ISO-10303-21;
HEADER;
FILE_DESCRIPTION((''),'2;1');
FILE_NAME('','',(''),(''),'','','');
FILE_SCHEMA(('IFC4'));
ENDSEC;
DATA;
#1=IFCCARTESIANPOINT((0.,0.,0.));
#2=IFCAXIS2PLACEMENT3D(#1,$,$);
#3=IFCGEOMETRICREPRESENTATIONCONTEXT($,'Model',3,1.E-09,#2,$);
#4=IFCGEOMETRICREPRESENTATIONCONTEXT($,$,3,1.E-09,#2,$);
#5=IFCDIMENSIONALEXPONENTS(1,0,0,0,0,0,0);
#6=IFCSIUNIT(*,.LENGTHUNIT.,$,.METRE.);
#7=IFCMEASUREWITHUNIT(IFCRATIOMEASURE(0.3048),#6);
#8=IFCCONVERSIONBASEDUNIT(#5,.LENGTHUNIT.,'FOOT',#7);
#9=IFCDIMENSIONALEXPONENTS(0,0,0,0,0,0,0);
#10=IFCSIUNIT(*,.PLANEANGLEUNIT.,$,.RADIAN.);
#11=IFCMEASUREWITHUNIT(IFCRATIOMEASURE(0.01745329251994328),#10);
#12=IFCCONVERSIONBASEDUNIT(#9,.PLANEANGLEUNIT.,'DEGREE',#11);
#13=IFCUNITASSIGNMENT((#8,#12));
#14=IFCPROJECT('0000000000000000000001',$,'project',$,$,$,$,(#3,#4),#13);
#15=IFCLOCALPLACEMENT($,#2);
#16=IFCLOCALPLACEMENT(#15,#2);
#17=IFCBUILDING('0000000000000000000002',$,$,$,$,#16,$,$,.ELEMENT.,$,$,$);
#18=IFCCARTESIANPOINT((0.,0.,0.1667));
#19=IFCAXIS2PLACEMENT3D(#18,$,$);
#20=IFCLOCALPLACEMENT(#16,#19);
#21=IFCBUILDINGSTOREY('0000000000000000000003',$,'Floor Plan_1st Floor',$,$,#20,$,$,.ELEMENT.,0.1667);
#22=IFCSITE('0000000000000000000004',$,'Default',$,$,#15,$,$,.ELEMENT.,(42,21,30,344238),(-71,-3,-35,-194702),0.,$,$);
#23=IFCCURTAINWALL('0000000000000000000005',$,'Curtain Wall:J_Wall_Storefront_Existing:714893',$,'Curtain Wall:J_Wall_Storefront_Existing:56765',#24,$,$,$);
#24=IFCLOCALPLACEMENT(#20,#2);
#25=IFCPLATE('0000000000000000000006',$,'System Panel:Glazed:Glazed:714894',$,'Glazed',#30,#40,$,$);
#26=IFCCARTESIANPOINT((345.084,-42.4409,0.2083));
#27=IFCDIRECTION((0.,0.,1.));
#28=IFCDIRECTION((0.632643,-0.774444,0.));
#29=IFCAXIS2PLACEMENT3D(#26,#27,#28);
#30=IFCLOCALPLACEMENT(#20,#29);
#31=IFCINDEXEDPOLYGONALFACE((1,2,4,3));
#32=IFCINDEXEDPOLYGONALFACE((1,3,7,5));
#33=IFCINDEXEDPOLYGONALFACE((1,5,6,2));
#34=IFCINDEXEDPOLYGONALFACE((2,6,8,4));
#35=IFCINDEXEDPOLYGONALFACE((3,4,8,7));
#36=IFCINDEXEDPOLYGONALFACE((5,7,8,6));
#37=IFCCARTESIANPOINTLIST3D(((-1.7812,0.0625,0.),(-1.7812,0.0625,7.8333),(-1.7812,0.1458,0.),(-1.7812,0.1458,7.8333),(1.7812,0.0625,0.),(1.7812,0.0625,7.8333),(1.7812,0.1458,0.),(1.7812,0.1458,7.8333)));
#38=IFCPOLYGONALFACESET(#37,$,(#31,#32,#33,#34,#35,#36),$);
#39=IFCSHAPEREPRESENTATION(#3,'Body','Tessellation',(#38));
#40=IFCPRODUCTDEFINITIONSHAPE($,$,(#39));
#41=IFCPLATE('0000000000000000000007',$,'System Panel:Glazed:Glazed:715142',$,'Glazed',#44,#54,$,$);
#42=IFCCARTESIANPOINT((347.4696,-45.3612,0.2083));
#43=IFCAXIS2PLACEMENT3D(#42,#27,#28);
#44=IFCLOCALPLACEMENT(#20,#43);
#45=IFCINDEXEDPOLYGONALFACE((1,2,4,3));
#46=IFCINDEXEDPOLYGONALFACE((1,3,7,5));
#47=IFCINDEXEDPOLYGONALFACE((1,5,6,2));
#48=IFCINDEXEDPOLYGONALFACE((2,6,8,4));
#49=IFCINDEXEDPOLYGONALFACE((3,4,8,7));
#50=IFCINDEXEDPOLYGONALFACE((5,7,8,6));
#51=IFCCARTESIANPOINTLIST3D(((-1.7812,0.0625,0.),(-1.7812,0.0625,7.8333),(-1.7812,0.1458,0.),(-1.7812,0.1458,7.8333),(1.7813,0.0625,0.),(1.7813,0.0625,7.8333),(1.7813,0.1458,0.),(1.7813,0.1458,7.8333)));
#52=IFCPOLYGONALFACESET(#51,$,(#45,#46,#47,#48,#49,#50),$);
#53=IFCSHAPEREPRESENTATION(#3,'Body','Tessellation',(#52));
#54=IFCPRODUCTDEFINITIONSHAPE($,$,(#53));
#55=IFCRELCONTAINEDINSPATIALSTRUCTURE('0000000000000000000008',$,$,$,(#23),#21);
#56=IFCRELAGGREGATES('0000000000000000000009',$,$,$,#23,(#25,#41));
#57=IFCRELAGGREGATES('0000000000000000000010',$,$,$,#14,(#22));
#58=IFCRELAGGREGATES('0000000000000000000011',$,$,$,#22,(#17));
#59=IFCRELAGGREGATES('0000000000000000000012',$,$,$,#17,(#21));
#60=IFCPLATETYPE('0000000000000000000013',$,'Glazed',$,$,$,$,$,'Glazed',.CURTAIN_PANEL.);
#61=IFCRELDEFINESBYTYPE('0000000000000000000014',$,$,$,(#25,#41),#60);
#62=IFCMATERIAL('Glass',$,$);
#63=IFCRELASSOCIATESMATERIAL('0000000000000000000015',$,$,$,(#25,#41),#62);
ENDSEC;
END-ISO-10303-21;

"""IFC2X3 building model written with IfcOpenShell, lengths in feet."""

from ifc_helpers import new_model, entity, si_unit, converted_unit, frame, origin, origin_2d_with_axis, place, context, project, spatial, rectangle, extrude, source, transform, mapped, material, type_object, type_shapes, element, aggregate, save


model = new_model("IFC2X3")

# Units and contexts
model_context = context("Model", 3, precision=1e-09, world=origin())
context_of_model = context(None, 3, precision=1e-09, world=origin())
ifc_project = project(units=[converted_unit("LENGTHUNIT", "FOOT", entity("IfcRatioMeasure", 0.3048), si_unit("LENGTHUNIT", "METRE"), dimensions=[1, 0, 0, 0, 0, 0, 0]), converted_unit("PLANEANGLEUNIT", "DEGREE", entity("IfcRatioMeasure", 0.01745329251994328), si_unit("PLANEANGLEUNIT", "RADIAN"), dimensions=[0, 0, 0, 0, 0, 0, 0])], contexts=[model_context, context_of_model])

# Site, building, storey
site_placement = place(None, origin())
site = spatial("IfcSite", under=ifc_project, at=site_placement, Name="Default", CompositionType="ELEMENT", RefLatitude=(42, 21, 30, 344238), RefLongitude=(-71, -3, -35, -194702), RefElevation=0.0)
building_placement = place(site_placement, origin())
building = spatial("IfcBuilding", under=site, at=building_placement, CompositionType="ELEMENT")
storey_placement = place(building_placement, frame((0.0, 0.0, 0.1667)))
storey = spatial("IfcBuildingStorey", under=building, at=storey_placement, Name="Floor Plan_1st Floor", CompositionType="ELEMENT", Elevation=0.1667)

# Curtain wall
curtain_wall_placement = place(storey_placement, origin())
curtain_wall = element("IfcCurtainWall", 1, at=curtain_wall_placement, inside=storey, Name="Curtain Wall:J_Wall_Storefront_Existing:714893", ObjectType="Curtain Wall:J_Wall_Storefront_Existing:56765")

# Plates
ifc_material_1 = material(Name="Glass")
plate_type = type_object("IfcPlateType", Name="Glazed", ElementType="Glazed", PredefinedType="CURTAIN_PANEL")
shared_shape_1 = source(origin(), model_context, "Body", "SweptSolid", [
    extrude(rectangle(XDim=0.0833, YDim=3.5625, at=origin_2d_with_axis()), frame((0.0, 0.1042, 0.0), z_axis=(0.0, 0.0, 1.0), x_axis=(0.0, 1.0, 0.0)), (0.0, 0.0, 1.0), 7.8333),
])
type_shapes(plate_type, [shared_shape_1])
plate_1_placement = place(storey_placement, frame((345.084, -42.4409, 0.2083), z_axis=(0.0, 0.0, 1.0), x_axis=(0.632643, -0.774444, 0.0)))
plate_1 = element("IfcPlate", 2, at=plate_1_placement, type_object=plate_type, material=ifc_material_1, Name="System Panel:Glazed:Glazed:714894", ObjectType="Glazed", context=model_context, shape_type="MappedRepresentation", body=[
    mapped(shared_shape_1, transform((0.0, 0.0, 0.0), scale=1.0)),
])
plate_2_placement = place(storey_placement, frame((347.4696, -45.3612, 0.2083), z_axis=(0.0, 0.0, 1.0), x_axis=(0.632643, -0.774444, 0.0)))
plate_2 = element("IfcPlate", 3, at=plate_2_placement, type_object=plate_type, material=ifc_material_1, Name="System Panel:Glazed:Glazed:715142", ObjectType="Glazed", context=model_context, shape_type="MappedRepresentation", body=[
    mapped(shared_shape_1, transform((0.0, 0.0, 0.0), scale=1.0)),
])
aggregate(curtain_wall, [plate_1, plate_2])

save(model, "model.ifc")
